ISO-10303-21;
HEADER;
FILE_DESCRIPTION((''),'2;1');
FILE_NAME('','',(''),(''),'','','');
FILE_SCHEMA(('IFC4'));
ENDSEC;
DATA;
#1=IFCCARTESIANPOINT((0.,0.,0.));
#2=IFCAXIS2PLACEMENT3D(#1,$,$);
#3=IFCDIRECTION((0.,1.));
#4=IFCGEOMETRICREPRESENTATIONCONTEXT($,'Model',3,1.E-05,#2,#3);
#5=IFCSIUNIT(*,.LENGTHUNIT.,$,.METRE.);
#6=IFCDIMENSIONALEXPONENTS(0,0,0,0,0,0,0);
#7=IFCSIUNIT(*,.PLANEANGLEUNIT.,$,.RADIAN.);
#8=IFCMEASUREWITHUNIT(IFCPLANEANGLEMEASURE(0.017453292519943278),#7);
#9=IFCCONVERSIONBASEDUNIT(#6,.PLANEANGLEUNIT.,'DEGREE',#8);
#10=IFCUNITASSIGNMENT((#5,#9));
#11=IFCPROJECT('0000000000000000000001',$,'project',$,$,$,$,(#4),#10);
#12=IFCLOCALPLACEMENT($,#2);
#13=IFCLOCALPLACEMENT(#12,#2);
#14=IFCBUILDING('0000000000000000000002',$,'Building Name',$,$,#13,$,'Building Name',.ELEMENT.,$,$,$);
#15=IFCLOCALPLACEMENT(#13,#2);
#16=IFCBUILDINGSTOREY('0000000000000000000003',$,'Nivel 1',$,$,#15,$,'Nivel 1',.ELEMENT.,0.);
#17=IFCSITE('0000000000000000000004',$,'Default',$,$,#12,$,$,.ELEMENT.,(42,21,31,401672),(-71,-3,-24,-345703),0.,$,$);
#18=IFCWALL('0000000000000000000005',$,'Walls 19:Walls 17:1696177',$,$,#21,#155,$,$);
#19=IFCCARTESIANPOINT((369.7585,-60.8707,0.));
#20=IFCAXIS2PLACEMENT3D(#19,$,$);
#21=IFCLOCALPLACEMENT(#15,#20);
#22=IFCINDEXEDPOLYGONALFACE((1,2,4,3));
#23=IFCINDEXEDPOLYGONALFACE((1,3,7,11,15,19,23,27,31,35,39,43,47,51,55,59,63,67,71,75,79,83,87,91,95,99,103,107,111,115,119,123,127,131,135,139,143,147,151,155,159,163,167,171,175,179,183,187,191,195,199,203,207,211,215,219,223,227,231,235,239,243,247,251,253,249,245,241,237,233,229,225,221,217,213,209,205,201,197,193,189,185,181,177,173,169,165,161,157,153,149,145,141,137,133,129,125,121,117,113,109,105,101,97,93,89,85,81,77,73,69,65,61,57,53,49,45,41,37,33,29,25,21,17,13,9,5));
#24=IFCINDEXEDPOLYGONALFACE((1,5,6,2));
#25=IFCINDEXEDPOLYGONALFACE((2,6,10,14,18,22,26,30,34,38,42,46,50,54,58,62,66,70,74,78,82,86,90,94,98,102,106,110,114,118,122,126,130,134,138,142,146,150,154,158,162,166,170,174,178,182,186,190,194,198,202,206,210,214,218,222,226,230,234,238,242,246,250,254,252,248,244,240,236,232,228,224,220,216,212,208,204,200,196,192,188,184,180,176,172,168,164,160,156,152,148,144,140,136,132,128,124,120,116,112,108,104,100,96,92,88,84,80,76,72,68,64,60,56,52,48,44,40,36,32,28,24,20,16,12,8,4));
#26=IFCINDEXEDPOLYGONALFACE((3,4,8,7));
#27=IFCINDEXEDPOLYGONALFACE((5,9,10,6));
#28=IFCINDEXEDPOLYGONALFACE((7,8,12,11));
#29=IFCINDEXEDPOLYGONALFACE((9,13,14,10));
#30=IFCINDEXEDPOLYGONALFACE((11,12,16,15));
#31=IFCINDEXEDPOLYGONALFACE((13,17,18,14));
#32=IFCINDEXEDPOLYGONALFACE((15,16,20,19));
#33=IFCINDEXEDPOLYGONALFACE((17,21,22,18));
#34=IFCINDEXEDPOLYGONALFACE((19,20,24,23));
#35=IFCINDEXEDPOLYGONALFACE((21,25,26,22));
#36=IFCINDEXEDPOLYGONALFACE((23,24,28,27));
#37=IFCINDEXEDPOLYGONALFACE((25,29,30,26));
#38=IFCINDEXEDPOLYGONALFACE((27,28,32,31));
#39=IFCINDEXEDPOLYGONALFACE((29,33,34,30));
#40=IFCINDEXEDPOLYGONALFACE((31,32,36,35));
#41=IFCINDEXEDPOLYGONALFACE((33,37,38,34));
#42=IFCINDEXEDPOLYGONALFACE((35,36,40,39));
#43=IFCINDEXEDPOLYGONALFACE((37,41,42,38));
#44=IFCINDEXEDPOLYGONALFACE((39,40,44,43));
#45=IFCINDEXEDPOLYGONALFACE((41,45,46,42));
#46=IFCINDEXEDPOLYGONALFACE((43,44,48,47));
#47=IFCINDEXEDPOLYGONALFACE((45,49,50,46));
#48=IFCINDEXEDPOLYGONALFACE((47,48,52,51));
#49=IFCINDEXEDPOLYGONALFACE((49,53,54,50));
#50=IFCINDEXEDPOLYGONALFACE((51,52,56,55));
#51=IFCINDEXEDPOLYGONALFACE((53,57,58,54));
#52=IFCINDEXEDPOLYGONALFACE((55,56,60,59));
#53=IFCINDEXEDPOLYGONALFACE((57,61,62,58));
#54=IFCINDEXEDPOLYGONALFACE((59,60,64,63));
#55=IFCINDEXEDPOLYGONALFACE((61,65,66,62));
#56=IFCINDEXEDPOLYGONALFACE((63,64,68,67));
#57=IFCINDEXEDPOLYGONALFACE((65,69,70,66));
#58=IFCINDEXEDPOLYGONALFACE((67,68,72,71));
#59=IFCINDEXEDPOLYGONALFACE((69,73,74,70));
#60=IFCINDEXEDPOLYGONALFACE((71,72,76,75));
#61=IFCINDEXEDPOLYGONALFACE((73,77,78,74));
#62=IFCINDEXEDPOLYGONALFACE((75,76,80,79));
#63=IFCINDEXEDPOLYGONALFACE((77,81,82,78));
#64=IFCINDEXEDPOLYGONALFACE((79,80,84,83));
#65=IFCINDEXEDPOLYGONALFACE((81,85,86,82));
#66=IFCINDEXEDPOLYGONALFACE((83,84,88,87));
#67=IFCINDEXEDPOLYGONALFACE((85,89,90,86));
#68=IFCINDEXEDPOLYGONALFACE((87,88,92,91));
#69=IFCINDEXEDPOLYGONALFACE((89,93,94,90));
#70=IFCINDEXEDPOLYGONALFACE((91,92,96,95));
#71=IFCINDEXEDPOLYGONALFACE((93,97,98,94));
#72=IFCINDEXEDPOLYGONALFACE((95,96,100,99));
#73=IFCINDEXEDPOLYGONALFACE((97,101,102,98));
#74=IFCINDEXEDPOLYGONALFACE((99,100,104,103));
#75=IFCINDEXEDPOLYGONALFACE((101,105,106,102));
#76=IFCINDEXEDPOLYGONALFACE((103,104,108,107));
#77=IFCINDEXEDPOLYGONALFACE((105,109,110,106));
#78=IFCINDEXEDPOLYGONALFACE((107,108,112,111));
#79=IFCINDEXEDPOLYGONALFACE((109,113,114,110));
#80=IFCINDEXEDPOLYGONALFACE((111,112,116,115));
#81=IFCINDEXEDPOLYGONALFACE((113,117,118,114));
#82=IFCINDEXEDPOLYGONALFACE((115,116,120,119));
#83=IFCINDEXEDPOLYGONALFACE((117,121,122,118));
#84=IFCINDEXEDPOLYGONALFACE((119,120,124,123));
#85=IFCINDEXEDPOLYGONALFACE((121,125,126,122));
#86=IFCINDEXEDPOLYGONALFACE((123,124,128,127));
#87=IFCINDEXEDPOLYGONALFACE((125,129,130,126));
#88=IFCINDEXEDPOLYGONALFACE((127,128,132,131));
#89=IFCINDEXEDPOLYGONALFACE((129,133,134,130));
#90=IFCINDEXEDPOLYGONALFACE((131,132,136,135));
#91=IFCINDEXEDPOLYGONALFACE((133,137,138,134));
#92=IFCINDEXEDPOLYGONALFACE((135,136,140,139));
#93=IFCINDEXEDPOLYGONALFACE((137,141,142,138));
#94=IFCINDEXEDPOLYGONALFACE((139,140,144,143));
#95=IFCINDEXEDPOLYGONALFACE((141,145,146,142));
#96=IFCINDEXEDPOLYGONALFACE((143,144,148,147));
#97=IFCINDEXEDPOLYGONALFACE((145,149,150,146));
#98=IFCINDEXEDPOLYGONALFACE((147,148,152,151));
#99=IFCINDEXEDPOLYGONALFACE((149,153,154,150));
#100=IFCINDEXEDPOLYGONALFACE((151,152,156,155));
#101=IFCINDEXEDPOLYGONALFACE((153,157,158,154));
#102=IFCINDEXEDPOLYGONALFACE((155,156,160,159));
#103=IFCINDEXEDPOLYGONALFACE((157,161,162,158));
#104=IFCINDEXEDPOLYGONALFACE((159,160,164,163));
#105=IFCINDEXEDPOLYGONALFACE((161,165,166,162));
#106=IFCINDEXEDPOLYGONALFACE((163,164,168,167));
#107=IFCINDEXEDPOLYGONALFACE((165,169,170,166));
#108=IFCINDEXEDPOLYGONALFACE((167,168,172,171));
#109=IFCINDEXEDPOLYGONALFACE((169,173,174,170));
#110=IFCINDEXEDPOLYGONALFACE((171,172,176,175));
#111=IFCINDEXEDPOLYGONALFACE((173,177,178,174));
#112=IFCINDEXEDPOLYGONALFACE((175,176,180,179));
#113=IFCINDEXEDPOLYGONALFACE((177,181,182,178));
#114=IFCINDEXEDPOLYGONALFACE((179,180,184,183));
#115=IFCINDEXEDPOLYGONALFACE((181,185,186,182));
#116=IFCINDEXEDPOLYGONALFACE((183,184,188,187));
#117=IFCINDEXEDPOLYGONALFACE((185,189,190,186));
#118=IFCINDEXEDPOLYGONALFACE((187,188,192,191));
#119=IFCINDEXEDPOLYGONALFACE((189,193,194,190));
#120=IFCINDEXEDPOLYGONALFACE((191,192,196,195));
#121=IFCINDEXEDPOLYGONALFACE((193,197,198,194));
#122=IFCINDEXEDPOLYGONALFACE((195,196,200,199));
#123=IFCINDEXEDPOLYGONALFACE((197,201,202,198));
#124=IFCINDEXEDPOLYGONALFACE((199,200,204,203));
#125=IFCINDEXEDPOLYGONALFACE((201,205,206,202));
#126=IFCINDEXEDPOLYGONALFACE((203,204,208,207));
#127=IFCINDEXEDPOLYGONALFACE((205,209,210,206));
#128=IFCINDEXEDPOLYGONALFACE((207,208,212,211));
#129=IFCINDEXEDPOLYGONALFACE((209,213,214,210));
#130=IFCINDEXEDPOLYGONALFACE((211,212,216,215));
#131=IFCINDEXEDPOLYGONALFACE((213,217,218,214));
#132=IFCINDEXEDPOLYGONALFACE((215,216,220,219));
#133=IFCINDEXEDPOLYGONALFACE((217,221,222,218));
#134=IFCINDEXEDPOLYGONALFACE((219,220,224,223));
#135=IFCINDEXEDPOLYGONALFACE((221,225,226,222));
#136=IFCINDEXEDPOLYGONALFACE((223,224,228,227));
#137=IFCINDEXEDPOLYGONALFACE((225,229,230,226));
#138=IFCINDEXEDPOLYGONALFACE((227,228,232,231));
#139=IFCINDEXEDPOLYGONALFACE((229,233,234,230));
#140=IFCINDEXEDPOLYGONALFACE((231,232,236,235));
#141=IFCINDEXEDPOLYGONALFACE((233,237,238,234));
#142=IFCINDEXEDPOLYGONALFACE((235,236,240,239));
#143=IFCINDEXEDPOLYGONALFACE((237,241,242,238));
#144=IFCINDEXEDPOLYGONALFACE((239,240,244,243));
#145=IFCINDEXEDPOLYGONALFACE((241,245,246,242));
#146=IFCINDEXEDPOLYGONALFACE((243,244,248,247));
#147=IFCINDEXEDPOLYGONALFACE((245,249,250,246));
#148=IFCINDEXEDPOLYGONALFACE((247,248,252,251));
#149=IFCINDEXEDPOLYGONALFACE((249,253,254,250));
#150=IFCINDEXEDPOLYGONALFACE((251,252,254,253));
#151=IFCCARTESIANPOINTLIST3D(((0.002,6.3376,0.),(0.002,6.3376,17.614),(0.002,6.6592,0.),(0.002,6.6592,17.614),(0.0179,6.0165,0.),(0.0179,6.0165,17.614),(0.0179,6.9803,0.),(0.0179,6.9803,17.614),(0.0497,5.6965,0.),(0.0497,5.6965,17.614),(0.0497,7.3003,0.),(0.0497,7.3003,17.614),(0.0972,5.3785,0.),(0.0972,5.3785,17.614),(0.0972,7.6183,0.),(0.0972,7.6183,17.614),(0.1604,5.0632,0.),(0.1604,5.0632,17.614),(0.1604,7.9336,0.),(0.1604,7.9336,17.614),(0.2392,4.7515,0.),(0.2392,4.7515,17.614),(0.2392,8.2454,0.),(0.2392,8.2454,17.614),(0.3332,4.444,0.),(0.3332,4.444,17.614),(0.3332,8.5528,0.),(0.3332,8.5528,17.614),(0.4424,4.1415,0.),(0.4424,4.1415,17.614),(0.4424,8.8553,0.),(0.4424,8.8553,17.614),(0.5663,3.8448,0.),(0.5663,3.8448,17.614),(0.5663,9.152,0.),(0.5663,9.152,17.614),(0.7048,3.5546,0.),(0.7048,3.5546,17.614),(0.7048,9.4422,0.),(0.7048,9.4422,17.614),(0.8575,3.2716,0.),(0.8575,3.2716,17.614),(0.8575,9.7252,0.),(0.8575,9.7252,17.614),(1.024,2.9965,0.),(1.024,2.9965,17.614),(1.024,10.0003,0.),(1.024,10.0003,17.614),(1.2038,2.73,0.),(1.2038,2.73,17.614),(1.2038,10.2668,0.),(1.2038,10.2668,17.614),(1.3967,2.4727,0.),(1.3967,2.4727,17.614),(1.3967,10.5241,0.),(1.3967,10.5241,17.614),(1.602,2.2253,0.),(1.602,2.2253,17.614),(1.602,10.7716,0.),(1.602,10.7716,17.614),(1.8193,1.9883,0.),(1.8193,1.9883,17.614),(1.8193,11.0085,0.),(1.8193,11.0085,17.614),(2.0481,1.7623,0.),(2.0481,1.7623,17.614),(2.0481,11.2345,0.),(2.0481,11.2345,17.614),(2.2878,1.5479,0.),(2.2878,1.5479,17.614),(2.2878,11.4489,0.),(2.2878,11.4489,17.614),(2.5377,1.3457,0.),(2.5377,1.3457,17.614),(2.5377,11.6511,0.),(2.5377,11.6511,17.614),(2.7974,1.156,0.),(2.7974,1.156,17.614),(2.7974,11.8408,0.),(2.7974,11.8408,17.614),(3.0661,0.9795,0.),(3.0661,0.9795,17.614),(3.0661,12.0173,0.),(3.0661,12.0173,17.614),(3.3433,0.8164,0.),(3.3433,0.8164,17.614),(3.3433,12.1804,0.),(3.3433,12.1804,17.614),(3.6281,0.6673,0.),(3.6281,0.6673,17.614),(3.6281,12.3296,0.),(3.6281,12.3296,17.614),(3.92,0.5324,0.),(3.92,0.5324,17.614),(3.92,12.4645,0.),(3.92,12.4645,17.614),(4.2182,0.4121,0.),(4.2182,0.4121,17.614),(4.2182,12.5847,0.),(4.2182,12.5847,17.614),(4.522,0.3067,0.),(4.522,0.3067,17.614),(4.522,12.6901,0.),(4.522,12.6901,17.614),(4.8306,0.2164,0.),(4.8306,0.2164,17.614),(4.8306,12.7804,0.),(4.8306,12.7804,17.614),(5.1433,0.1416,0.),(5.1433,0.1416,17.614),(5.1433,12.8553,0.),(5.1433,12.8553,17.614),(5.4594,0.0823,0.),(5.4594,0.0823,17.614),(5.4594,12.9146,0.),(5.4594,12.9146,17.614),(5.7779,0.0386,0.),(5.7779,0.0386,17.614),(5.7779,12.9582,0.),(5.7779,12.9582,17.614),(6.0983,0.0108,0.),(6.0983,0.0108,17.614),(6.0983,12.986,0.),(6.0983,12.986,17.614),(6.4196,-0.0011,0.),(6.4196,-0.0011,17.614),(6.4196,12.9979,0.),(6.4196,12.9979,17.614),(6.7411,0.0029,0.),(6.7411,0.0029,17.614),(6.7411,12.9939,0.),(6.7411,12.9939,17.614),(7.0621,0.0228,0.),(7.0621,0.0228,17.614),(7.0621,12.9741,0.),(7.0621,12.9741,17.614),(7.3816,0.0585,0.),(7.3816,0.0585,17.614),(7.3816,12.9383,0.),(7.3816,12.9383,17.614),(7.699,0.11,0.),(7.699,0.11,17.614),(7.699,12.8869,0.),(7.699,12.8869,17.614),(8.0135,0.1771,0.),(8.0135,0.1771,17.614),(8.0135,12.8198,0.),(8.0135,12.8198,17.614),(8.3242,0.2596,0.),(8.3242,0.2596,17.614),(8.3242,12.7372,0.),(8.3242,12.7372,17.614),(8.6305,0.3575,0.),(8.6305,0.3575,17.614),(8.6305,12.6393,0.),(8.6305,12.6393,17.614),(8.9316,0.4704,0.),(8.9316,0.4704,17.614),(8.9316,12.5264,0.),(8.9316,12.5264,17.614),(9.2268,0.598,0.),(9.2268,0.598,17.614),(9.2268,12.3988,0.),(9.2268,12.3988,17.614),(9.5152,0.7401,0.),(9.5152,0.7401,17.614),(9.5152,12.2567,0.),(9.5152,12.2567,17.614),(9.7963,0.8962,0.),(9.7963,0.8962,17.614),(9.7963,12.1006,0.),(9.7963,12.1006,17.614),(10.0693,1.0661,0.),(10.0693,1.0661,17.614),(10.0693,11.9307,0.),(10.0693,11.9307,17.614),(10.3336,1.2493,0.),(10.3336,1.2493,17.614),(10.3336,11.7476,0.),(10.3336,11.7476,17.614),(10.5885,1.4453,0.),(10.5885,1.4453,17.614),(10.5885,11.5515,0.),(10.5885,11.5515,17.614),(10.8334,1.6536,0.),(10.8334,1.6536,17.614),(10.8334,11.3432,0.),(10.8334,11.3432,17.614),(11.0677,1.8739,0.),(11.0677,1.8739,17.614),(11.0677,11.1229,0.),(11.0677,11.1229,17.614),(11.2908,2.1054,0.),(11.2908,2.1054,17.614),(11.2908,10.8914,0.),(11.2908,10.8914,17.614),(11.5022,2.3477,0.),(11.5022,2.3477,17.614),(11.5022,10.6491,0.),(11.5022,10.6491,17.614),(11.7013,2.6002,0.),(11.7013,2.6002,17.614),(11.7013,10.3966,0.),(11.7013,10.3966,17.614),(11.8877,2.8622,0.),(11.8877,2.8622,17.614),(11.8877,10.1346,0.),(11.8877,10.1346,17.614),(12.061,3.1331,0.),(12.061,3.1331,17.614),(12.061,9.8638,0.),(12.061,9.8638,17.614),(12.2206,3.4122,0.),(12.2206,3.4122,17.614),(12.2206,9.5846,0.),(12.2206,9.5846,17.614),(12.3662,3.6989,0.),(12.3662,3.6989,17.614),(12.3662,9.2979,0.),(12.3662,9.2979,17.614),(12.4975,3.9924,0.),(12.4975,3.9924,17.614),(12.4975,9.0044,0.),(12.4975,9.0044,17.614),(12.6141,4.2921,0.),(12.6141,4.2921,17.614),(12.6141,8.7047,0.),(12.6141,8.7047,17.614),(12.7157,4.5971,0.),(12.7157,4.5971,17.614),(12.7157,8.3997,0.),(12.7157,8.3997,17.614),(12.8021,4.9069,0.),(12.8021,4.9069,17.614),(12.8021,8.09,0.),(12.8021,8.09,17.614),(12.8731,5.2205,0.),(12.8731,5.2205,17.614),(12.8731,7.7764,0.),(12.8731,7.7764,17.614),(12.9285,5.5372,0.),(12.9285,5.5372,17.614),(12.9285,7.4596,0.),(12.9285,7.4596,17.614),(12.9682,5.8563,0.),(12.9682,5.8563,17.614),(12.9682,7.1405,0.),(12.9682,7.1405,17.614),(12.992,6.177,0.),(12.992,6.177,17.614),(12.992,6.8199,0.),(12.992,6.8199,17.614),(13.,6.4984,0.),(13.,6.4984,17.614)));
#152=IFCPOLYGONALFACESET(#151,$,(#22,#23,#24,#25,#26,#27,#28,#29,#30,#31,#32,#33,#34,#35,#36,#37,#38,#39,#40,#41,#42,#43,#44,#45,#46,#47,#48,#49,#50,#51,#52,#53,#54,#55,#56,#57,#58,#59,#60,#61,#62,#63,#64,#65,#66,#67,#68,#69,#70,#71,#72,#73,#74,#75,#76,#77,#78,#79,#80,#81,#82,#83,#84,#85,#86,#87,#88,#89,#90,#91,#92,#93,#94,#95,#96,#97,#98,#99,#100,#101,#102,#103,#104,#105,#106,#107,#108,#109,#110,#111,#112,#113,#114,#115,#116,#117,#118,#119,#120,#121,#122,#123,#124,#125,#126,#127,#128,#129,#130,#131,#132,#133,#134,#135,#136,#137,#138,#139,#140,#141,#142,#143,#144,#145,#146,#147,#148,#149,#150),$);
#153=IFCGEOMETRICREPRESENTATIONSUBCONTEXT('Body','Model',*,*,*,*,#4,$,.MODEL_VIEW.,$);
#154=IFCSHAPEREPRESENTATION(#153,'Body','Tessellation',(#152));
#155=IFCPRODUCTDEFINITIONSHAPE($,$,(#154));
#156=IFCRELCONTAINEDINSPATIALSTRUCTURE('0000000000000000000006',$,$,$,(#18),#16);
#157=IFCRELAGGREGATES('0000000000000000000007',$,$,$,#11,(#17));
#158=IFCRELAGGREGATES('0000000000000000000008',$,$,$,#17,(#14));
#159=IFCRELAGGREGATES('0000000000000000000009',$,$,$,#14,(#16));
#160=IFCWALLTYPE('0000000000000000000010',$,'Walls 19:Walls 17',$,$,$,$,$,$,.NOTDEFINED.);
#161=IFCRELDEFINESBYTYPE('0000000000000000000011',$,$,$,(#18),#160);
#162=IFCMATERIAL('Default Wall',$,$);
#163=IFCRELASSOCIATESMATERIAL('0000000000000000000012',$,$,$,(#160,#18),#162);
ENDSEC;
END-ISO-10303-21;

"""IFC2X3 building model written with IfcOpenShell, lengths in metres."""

from ifc_helpers import new_model, entity, si_unit, converted_unit, direction, frame, frame_2d, origin, place, context, subcontext, project, spatial, circle, extrude, material, type_object, element, save


model = new_model("IFC2X3")

# Units and contexts
model_context = context("Model", 3, precision=1e-05, world=origin(), true_north=direction((0.0, 1.0)))
body_context = subcontext(model_context, "Body", "Model", "MODEL_VIEW")
ifc_project = project(units=[si_unit("LENGTHUNIT", "METRE"), converted_unit("PLANEANGLEUNIT", "DEGREE", entity("IfcPlaneAngleMeasure", 0.017453292519943278), si_unit("PLANEANGLEUNIT", "RADIAN"), dimensions=[0, 0, 0, 0, 0, 0, 0])], contexts=[model_context])

# Site, building, storey
site_placement = place(None, origin())
site = spatial("IfcSite", under=ifc_project, at=site_placement, Name="Default", CompositionType="ELEMENT", RefLatitude=(42, 21, 31, 401672), RefLongitude=(-71, -3, -24, -345703), RefElevation=0.0)
building_placement = place(site_placement, origin())
building = spatial("IfcBuilding", under=site, at=building_placement, Name="Building Name", LongName="Building Name", CompositionType="ELEMENT")
storey_placement = place(building_placement, origin())
storey = spatial("IfcBuildingStorey", under=building, at=storey_placement, Name="Nivel 1", LongName="Nivel 1", CompositionType="ELEMENT", Elevation=0.0)

# Wall
ifc_material_1 = material(Name="Default Wall")
wall_type_1 = type_object("IfcWallType", Name="Walls 19:Walls 17", PredefinedType="NOTDEFINED", material=ifc_material_1)
wall_1_placement = place(storey_placement, frame((369.7585, -60.8707, 0.0)))
element("IfcWall", 1, at=wall_1_placement, inside=storey, type_object=wall_type_1, material=ifc_material_1, Name="Walls 19:Walls 17:1696177", context=body_context, shape_type="SweptSolid", body=[
    extrude(circle(Radius=6.5, at=frame_2d((0.0, 0.0), x_axis=(1.0, 0.0))), frame((6.5, 6.4984, 0.0)), (0.0, 0.0, 1.0), 17.614),
])

save(model, "model.ifc")
